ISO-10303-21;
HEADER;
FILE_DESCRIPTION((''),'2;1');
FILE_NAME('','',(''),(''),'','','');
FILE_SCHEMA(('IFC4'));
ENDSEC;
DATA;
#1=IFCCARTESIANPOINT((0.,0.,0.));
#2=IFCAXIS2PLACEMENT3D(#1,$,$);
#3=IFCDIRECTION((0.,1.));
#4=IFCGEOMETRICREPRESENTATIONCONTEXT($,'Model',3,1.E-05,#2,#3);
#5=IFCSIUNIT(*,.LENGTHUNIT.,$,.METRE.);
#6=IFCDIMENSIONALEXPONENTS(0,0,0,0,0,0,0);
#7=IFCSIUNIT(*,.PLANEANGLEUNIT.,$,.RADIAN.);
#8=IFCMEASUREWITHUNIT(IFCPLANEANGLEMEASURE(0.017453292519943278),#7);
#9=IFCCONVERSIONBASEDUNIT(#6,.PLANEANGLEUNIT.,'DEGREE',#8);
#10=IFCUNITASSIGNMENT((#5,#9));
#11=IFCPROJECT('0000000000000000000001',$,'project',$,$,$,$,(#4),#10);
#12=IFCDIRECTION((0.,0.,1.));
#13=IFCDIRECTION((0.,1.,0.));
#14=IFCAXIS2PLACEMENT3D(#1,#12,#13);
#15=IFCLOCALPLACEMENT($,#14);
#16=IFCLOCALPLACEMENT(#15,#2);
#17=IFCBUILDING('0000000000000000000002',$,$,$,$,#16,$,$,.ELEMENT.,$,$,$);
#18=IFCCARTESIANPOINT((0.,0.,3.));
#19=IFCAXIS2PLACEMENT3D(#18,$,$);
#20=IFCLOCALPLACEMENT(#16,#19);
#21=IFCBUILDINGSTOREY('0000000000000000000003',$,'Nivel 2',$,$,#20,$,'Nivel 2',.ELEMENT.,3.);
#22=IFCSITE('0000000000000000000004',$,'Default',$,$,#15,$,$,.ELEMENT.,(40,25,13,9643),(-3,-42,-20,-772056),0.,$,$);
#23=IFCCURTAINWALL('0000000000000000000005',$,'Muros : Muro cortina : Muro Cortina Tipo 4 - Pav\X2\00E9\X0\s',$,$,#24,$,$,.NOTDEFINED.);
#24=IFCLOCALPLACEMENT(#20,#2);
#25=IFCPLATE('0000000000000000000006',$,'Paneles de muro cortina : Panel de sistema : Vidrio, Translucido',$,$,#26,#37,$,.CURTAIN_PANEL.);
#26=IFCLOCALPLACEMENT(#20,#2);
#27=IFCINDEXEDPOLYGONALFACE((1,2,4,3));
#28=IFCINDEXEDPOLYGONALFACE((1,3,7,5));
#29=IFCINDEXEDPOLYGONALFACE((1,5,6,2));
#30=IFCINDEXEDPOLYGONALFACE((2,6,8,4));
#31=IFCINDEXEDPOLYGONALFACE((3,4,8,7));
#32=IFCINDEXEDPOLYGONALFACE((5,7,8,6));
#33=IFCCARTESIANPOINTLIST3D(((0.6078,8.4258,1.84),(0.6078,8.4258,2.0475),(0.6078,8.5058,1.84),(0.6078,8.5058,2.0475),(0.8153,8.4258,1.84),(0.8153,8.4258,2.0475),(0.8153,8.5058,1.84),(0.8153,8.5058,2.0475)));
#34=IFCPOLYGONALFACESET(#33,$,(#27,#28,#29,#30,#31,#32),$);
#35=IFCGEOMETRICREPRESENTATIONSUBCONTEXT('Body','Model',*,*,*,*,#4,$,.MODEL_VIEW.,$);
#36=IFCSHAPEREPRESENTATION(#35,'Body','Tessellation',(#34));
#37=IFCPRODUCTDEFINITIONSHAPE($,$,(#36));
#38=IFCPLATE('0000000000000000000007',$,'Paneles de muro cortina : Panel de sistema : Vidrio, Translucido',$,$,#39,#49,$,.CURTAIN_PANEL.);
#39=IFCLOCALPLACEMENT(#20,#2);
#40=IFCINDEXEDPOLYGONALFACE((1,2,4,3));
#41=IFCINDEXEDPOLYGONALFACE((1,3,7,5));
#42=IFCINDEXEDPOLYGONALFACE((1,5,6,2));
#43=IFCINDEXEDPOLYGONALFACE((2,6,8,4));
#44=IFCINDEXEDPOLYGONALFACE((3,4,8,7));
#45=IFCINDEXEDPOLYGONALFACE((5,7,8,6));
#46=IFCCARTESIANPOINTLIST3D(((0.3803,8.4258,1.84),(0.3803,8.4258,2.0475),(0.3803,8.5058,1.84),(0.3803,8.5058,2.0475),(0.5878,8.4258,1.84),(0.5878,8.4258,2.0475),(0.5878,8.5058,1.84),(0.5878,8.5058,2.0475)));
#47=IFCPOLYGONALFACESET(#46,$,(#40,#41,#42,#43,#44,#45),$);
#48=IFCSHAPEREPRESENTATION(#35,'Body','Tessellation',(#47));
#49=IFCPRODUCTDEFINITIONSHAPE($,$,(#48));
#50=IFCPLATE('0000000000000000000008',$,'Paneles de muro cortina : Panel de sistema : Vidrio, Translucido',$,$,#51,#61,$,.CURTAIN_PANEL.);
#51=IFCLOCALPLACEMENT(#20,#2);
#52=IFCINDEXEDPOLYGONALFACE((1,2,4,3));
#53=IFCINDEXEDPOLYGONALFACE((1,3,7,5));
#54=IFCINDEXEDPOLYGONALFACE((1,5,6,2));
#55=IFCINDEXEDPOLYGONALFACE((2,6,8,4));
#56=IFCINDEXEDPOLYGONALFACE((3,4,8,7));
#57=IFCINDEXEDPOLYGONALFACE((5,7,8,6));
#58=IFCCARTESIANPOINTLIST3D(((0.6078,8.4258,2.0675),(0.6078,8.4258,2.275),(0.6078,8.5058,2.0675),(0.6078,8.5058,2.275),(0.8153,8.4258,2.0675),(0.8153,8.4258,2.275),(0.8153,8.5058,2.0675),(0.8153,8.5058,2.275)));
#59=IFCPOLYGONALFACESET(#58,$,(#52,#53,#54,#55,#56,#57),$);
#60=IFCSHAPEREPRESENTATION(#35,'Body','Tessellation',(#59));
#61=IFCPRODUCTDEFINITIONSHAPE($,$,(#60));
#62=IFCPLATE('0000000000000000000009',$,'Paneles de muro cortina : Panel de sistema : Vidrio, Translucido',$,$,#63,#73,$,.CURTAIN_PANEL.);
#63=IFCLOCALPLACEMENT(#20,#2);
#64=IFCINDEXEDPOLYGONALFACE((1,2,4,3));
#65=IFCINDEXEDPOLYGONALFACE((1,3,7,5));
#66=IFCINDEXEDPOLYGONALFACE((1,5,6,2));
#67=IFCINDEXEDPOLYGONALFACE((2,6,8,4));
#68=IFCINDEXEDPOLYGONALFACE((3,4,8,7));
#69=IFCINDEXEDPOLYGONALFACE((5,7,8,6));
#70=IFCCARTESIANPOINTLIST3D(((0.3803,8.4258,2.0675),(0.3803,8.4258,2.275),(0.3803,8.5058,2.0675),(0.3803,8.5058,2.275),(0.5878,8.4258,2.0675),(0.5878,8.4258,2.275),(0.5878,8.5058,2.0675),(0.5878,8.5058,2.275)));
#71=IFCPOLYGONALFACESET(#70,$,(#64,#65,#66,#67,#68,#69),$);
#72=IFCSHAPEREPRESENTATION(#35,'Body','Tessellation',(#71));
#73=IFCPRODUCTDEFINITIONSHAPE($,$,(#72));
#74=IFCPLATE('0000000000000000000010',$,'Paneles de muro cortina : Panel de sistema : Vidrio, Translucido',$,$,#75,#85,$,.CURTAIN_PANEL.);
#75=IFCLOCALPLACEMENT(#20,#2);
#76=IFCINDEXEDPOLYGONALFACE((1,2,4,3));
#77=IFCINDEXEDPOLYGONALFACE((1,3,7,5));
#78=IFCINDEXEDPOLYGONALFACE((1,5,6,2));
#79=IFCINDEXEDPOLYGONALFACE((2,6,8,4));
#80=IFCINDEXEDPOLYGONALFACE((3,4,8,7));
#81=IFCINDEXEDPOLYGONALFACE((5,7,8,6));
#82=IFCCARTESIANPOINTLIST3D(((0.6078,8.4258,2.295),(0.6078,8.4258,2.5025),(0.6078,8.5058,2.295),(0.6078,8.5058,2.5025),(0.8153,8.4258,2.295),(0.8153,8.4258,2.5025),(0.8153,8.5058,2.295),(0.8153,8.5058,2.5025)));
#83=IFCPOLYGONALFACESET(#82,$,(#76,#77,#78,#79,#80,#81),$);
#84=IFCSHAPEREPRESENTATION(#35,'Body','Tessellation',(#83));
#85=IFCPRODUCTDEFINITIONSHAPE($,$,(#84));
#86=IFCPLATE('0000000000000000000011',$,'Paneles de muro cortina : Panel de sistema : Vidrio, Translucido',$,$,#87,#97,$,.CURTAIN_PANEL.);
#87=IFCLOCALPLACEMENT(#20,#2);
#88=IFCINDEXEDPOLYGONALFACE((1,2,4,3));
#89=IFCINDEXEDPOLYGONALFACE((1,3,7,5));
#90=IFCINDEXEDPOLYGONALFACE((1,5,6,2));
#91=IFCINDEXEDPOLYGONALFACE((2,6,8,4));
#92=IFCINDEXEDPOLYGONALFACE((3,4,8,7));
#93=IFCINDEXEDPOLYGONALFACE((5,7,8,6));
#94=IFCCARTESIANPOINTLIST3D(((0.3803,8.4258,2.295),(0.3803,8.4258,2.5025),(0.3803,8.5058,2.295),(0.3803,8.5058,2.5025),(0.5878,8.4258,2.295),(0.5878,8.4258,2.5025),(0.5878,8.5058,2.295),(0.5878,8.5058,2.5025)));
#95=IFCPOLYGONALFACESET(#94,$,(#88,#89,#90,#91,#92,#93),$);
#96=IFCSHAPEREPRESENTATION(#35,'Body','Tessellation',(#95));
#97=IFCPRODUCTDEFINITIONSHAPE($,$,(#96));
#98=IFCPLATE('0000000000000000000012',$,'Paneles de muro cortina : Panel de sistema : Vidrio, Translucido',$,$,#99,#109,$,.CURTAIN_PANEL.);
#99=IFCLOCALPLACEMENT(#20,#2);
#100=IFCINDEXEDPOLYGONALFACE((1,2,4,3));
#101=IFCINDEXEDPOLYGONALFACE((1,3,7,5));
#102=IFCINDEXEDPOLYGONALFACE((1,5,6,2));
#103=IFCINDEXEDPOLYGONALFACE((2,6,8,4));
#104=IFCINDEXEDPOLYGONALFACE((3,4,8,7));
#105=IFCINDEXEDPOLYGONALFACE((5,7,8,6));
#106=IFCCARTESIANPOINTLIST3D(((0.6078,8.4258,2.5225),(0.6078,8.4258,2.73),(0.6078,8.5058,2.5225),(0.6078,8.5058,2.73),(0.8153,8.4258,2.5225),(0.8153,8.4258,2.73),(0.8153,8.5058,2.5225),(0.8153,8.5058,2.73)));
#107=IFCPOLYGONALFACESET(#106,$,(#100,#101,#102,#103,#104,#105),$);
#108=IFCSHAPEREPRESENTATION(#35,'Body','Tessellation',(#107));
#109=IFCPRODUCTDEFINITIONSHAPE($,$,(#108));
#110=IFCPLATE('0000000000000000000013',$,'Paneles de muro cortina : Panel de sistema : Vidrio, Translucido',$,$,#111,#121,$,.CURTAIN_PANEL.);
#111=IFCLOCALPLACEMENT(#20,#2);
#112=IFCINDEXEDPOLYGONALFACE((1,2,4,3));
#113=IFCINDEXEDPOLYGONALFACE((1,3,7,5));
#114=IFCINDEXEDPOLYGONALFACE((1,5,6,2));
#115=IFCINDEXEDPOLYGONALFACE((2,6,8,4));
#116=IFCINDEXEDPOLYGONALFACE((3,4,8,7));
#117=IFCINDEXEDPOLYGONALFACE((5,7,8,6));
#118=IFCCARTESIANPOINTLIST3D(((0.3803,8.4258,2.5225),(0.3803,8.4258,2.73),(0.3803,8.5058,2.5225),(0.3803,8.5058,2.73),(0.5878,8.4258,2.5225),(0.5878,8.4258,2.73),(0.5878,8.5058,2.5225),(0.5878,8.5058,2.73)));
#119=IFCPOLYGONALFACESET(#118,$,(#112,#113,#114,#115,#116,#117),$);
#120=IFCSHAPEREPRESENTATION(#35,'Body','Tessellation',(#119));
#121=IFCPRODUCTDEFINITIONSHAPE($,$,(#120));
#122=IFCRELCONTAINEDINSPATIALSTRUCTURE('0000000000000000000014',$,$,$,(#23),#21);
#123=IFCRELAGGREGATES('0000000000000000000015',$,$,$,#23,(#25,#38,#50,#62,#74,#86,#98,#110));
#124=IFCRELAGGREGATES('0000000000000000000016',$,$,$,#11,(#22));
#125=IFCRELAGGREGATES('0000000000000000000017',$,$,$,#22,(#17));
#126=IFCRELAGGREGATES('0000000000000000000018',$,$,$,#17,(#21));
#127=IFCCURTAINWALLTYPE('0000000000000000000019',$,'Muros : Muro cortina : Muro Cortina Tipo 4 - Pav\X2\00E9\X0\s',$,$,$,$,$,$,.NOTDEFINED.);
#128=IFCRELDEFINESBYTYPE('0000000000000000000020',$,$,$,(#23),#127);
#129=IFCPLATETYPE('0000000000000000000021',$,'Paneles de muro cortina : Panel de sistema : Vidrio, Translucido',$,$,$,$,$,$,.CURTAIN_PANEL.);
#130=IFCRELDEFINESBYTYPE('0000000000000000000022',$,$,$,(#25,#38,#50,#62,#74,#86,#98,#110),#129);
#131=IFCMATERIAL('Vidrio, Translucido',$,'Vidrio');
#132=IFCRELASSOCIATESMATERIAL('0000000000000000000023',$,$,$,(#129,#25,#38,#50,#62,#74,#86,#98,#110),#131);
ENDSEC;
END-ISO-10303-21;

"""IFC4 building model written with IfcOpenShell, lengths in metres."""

from ifc_helpers import new_model, entity, si_unit, converted_unit, direction, frame, origin, place, context, subcontext, project, spatial, indexed_curve, outline, extrude, source, transform, mapped, material, type_object, type_shapes, element, aggregate, save


model = new_model("IFC4")

# Units and contexts
model_context = context("Model", 3, precision=1e-05, world=origin(), true_north=direction((0.0, 1.0)))
body_context = subcontext(model_context, "Body", "Model", "MODEL_VIEW")
ifc_project = project(units=[si_unit("LENGTHUNIT", "METRE"), converted_unit("PLANEANGLEUNIT", "DEGREE", entity("IfcPlaneAngleMeasure", 0.017453292519943278), si_unit("PLANEANGLEUNIT", "RADIAN"), dimensions=[0, 0, 0, 0, 0, 0, 0])], contexts=[model_context])

# Site, building, storey
site_placement = place(None, frame((0.0, 0.0, 0.0), z_axis=(0.0, 0.0, 1.0), x_axis=(0.0, 1.0, 0.0)))
site = spatial("IfcSite", under=ifc_project, at=site_placement, Name="Default", CompositionType="ELEMENT", RefLatitude=(40, 25, 13, 9643), RefLongitude=(-3, -42, -20, -772056), RefElevation=0.0)
building_placement = place(site_placement, origin())
building = spatial("IfcBuilding", under=site, at=building_placement, CompositionType="ELEMENT")
storey_placement = place(building_placement, frame((0.0, 0.0, 3.0)))
storey = spatial("IfcBuildingStorey", under=building, at=storey_placement, Name="Nivel 2", LongName="Nivel 2", CompositionType="ELEMENT", Elevation=3.0)

# Curtain wall, plates
curtain_wall_type = type_object("IfcCurtainWallType", Name="Muros : Muro cortina : Muro Cortina Tipo 4 - Pavés", PredefinedType="NOTDEFINED")
curtain_wall_placement = place(storey_placement, frame((0.0, 0.0, -3.0)))
curtain_wall = element("IfcCurtainWall", 1, at=curtain_wall_placement, inside=storey, type_object=curtain_wall_type, Name="Muros : Muro cortina : Muro Cortina Tipo 4 - Pavés", PredefinedType="NOTDEFINED")
ifc_material_1 = material(Name="Vidrio, Translucido", Category="Vidrio")
plate_type = type_object("IfcPlateType", Name="Paneles de muro cortina : Panel de sistema : Vidrio, Translucido", PredefinedType="CURTAIN_PANEL", material=ifc_material_1)
shared_shape_1 = source(origin(), body_context, "Body", "SweptSolid", [
    extrude(outline(indexed_curve([(-0.04, -0.1038), (0.04, -0.1038), (0.04, 0.1038), (-0.04, 0.1038), (-0.04, -0.1038)], self_intersect=False)), frame((0.0, 0.0, 0.0), z_axis=(0.0, 0.0, 1.0), x_axis=(0.0, 1.0, 0.0)), (0.0, 0.0, 1.0), 0.2075),
])
type_shapes(plate_type, [shared_shape_1])
plate_1_placement = place(curtain_wall_placement, frame((0.7115, 8.4658, 4.84), z_axis=(0.0, 0.0, 1.0), x_axis=(-1.0, 0.0, 0.0)))
plate_1 = element("IfcPlate", 2, at=plate_1_placement, type_object=plate_type, material=ifc_material_1, Name="Paneles de muro cortina : Panel de sistema : Vidrio, Translucido", PredefinedType="CURTAIN_PANEL", context=body_context, shape_type="MappedRepresentation", body=[
    mapped(shared_shape_1, transform((0.0, 0.0, 0.0), scale=1.0)),
])
plate_2_placement = place(curtain_wall_placement, frame((0.484, 8.4658, 4.84), z_axis=(0.0, 0.0, 1.0), x_axis=(-1.0, 0.0, 0.0)))
plate_2 = element("IfcPlate", 3, at=plate_2_placement, type_object=plate_type, material=ifc_material_1, Name="Paneles de muro cortina : Panel de sistema : Vidrio, Translucido", PredefinedType="CURTAIN_PANEL", context=body_context, shape_type="MappedRepresentation", body=[
    mapped(shared_shape_1, transform((0.0, 0.0, 0.0), scale=1.0)),
])
plate_3_placement = place(curtain_wall_placement, frame((0.7115, 8.4658, 5.0675), z_axis=(0.0, 0.0, 1.0), x_axis=(-1.0, 0.0, 0.0)))
plate_3 = element("IfcPlate", 4, at=plate_3_placement, type_object=plate_type, material=ifc_material_1, Name="Paneles de muro cortina : Panel de sistema : Vidrio, Translucido", PredefinedType="CURTAIN_PANEL", context=body_context, shape_type="MappedRepresentation", body=[
    mapped(shared_shape_1, transform((0.0, 0.0, 0.0), scale=1.0)),
])
plate_4_placement = place(curtain_wall_placement, frame((0.484, 8.4658, 5.0675), z_axis=(0.0, 0.0, 1.0), x_axis=(-1.0, 0.0, 0.0)))
plate_4 = element("IfcPlate", 5, at=plate_4_placement, type_object=plate_type, material=ifc_material_1, Name="Paneles de muro cortina : Panel de sistema : Vidrio, Translucido", PredefinedType="CURTAIN_PANEL", context=body_context, shape_type="MappedRepresentation", body=[
    mapped(shared_shape_1, transform((0.0, 0.0, 0.0), scale=1.0)),
])
plate_5_placement = place(curtain_wall_placement, frame((0.7115, 8.4658, 5.295), z_axis=(0.0, 0.0, 1.0), x_axis=(-1.0, 0.0, 0.0)))
plate_5 = element("IfcPlate", 6, at=plate_5_placement, type_object=plate_type, material=ifc_material_1, Name="Paneles de muro cortina : Panel de sistema : Vidrio, Translucido", PredefinedType="CURTAIN_PANEL", context=body_context, shape_type="MappedRepresentation", body=[
    mapped(shared_shape_1, transform((0.0, 0.0, 0.0), scale=1.0)),
])
plate_6_placement = place(curtain_wall_placement, frame((0.484, 8.4658, 5.295), z_axis=(0.0, 0.0, 1.0), x_axis=(-1.0, 0.0, 0.0)))
plate_6 = element("IfcPlate", 7, at=plate_6_placement, type_object=plate_type, material=ifc_material_1, Name="Paneles de muro cortina : Panel de sistema : Vidrio, Translucido", PredefinedType="CURTAIN_PANEL", context=body_context, shape_type="MappedRepresentation", body=[
    mapped(shared_shape_1, transform((0.0, 0.0, 0.0), scale=1.0)),
])
plate_7_placement = place(curtain_wall_placement, frame((0.7115, 8.4658, 5.5225), z_axis=(0.0, 0.0, 1.0), x_axis=(-1.0, 0.0, 0.0)))
plate_7 = element("IfcPlate", 8, at=plate_7_placement, type_object=plate_type, material=ifc_material_1, Name="Paneles de muro cortina : Panel de sistema : Vidrio, Translucido", PredefinedType="CURTAIN_PANEL", context=body_context, shape_type="MappedRepresentation", body=[
    mapped(shared_shape_1, transform((0.0, 0.0, 0.0), scale=1.0)),
])
plate_8_placement = place(curtain_wall_placement, frame((0.484, 8.4658, 5.5225), z_axis=(0.0, 0.0, 1.0), x_axis=(-1.0, 0.0, 0.0)))
plate_8 = element("IfcPlate", 9, at=plate_8_placement, type_object=plate_type, material=ifc_material_1, Name="Paneles de muro cortina : Panel de sistema : Vidrio, Translucido", PredefinedType="CURTAIN_PANEL", context=body_context, shape_type="MappedRepresentation", body=[
    mapped(shared_shape_1, transform((0.0, 0.0, 0.0), scale=1.0)),
])
aggregate(curtain_wall, [plate_1, plate_2, plate_3, plate_4, plate_5, plate_6, plate_7, plate_8])

save(model, "model.ifc")
